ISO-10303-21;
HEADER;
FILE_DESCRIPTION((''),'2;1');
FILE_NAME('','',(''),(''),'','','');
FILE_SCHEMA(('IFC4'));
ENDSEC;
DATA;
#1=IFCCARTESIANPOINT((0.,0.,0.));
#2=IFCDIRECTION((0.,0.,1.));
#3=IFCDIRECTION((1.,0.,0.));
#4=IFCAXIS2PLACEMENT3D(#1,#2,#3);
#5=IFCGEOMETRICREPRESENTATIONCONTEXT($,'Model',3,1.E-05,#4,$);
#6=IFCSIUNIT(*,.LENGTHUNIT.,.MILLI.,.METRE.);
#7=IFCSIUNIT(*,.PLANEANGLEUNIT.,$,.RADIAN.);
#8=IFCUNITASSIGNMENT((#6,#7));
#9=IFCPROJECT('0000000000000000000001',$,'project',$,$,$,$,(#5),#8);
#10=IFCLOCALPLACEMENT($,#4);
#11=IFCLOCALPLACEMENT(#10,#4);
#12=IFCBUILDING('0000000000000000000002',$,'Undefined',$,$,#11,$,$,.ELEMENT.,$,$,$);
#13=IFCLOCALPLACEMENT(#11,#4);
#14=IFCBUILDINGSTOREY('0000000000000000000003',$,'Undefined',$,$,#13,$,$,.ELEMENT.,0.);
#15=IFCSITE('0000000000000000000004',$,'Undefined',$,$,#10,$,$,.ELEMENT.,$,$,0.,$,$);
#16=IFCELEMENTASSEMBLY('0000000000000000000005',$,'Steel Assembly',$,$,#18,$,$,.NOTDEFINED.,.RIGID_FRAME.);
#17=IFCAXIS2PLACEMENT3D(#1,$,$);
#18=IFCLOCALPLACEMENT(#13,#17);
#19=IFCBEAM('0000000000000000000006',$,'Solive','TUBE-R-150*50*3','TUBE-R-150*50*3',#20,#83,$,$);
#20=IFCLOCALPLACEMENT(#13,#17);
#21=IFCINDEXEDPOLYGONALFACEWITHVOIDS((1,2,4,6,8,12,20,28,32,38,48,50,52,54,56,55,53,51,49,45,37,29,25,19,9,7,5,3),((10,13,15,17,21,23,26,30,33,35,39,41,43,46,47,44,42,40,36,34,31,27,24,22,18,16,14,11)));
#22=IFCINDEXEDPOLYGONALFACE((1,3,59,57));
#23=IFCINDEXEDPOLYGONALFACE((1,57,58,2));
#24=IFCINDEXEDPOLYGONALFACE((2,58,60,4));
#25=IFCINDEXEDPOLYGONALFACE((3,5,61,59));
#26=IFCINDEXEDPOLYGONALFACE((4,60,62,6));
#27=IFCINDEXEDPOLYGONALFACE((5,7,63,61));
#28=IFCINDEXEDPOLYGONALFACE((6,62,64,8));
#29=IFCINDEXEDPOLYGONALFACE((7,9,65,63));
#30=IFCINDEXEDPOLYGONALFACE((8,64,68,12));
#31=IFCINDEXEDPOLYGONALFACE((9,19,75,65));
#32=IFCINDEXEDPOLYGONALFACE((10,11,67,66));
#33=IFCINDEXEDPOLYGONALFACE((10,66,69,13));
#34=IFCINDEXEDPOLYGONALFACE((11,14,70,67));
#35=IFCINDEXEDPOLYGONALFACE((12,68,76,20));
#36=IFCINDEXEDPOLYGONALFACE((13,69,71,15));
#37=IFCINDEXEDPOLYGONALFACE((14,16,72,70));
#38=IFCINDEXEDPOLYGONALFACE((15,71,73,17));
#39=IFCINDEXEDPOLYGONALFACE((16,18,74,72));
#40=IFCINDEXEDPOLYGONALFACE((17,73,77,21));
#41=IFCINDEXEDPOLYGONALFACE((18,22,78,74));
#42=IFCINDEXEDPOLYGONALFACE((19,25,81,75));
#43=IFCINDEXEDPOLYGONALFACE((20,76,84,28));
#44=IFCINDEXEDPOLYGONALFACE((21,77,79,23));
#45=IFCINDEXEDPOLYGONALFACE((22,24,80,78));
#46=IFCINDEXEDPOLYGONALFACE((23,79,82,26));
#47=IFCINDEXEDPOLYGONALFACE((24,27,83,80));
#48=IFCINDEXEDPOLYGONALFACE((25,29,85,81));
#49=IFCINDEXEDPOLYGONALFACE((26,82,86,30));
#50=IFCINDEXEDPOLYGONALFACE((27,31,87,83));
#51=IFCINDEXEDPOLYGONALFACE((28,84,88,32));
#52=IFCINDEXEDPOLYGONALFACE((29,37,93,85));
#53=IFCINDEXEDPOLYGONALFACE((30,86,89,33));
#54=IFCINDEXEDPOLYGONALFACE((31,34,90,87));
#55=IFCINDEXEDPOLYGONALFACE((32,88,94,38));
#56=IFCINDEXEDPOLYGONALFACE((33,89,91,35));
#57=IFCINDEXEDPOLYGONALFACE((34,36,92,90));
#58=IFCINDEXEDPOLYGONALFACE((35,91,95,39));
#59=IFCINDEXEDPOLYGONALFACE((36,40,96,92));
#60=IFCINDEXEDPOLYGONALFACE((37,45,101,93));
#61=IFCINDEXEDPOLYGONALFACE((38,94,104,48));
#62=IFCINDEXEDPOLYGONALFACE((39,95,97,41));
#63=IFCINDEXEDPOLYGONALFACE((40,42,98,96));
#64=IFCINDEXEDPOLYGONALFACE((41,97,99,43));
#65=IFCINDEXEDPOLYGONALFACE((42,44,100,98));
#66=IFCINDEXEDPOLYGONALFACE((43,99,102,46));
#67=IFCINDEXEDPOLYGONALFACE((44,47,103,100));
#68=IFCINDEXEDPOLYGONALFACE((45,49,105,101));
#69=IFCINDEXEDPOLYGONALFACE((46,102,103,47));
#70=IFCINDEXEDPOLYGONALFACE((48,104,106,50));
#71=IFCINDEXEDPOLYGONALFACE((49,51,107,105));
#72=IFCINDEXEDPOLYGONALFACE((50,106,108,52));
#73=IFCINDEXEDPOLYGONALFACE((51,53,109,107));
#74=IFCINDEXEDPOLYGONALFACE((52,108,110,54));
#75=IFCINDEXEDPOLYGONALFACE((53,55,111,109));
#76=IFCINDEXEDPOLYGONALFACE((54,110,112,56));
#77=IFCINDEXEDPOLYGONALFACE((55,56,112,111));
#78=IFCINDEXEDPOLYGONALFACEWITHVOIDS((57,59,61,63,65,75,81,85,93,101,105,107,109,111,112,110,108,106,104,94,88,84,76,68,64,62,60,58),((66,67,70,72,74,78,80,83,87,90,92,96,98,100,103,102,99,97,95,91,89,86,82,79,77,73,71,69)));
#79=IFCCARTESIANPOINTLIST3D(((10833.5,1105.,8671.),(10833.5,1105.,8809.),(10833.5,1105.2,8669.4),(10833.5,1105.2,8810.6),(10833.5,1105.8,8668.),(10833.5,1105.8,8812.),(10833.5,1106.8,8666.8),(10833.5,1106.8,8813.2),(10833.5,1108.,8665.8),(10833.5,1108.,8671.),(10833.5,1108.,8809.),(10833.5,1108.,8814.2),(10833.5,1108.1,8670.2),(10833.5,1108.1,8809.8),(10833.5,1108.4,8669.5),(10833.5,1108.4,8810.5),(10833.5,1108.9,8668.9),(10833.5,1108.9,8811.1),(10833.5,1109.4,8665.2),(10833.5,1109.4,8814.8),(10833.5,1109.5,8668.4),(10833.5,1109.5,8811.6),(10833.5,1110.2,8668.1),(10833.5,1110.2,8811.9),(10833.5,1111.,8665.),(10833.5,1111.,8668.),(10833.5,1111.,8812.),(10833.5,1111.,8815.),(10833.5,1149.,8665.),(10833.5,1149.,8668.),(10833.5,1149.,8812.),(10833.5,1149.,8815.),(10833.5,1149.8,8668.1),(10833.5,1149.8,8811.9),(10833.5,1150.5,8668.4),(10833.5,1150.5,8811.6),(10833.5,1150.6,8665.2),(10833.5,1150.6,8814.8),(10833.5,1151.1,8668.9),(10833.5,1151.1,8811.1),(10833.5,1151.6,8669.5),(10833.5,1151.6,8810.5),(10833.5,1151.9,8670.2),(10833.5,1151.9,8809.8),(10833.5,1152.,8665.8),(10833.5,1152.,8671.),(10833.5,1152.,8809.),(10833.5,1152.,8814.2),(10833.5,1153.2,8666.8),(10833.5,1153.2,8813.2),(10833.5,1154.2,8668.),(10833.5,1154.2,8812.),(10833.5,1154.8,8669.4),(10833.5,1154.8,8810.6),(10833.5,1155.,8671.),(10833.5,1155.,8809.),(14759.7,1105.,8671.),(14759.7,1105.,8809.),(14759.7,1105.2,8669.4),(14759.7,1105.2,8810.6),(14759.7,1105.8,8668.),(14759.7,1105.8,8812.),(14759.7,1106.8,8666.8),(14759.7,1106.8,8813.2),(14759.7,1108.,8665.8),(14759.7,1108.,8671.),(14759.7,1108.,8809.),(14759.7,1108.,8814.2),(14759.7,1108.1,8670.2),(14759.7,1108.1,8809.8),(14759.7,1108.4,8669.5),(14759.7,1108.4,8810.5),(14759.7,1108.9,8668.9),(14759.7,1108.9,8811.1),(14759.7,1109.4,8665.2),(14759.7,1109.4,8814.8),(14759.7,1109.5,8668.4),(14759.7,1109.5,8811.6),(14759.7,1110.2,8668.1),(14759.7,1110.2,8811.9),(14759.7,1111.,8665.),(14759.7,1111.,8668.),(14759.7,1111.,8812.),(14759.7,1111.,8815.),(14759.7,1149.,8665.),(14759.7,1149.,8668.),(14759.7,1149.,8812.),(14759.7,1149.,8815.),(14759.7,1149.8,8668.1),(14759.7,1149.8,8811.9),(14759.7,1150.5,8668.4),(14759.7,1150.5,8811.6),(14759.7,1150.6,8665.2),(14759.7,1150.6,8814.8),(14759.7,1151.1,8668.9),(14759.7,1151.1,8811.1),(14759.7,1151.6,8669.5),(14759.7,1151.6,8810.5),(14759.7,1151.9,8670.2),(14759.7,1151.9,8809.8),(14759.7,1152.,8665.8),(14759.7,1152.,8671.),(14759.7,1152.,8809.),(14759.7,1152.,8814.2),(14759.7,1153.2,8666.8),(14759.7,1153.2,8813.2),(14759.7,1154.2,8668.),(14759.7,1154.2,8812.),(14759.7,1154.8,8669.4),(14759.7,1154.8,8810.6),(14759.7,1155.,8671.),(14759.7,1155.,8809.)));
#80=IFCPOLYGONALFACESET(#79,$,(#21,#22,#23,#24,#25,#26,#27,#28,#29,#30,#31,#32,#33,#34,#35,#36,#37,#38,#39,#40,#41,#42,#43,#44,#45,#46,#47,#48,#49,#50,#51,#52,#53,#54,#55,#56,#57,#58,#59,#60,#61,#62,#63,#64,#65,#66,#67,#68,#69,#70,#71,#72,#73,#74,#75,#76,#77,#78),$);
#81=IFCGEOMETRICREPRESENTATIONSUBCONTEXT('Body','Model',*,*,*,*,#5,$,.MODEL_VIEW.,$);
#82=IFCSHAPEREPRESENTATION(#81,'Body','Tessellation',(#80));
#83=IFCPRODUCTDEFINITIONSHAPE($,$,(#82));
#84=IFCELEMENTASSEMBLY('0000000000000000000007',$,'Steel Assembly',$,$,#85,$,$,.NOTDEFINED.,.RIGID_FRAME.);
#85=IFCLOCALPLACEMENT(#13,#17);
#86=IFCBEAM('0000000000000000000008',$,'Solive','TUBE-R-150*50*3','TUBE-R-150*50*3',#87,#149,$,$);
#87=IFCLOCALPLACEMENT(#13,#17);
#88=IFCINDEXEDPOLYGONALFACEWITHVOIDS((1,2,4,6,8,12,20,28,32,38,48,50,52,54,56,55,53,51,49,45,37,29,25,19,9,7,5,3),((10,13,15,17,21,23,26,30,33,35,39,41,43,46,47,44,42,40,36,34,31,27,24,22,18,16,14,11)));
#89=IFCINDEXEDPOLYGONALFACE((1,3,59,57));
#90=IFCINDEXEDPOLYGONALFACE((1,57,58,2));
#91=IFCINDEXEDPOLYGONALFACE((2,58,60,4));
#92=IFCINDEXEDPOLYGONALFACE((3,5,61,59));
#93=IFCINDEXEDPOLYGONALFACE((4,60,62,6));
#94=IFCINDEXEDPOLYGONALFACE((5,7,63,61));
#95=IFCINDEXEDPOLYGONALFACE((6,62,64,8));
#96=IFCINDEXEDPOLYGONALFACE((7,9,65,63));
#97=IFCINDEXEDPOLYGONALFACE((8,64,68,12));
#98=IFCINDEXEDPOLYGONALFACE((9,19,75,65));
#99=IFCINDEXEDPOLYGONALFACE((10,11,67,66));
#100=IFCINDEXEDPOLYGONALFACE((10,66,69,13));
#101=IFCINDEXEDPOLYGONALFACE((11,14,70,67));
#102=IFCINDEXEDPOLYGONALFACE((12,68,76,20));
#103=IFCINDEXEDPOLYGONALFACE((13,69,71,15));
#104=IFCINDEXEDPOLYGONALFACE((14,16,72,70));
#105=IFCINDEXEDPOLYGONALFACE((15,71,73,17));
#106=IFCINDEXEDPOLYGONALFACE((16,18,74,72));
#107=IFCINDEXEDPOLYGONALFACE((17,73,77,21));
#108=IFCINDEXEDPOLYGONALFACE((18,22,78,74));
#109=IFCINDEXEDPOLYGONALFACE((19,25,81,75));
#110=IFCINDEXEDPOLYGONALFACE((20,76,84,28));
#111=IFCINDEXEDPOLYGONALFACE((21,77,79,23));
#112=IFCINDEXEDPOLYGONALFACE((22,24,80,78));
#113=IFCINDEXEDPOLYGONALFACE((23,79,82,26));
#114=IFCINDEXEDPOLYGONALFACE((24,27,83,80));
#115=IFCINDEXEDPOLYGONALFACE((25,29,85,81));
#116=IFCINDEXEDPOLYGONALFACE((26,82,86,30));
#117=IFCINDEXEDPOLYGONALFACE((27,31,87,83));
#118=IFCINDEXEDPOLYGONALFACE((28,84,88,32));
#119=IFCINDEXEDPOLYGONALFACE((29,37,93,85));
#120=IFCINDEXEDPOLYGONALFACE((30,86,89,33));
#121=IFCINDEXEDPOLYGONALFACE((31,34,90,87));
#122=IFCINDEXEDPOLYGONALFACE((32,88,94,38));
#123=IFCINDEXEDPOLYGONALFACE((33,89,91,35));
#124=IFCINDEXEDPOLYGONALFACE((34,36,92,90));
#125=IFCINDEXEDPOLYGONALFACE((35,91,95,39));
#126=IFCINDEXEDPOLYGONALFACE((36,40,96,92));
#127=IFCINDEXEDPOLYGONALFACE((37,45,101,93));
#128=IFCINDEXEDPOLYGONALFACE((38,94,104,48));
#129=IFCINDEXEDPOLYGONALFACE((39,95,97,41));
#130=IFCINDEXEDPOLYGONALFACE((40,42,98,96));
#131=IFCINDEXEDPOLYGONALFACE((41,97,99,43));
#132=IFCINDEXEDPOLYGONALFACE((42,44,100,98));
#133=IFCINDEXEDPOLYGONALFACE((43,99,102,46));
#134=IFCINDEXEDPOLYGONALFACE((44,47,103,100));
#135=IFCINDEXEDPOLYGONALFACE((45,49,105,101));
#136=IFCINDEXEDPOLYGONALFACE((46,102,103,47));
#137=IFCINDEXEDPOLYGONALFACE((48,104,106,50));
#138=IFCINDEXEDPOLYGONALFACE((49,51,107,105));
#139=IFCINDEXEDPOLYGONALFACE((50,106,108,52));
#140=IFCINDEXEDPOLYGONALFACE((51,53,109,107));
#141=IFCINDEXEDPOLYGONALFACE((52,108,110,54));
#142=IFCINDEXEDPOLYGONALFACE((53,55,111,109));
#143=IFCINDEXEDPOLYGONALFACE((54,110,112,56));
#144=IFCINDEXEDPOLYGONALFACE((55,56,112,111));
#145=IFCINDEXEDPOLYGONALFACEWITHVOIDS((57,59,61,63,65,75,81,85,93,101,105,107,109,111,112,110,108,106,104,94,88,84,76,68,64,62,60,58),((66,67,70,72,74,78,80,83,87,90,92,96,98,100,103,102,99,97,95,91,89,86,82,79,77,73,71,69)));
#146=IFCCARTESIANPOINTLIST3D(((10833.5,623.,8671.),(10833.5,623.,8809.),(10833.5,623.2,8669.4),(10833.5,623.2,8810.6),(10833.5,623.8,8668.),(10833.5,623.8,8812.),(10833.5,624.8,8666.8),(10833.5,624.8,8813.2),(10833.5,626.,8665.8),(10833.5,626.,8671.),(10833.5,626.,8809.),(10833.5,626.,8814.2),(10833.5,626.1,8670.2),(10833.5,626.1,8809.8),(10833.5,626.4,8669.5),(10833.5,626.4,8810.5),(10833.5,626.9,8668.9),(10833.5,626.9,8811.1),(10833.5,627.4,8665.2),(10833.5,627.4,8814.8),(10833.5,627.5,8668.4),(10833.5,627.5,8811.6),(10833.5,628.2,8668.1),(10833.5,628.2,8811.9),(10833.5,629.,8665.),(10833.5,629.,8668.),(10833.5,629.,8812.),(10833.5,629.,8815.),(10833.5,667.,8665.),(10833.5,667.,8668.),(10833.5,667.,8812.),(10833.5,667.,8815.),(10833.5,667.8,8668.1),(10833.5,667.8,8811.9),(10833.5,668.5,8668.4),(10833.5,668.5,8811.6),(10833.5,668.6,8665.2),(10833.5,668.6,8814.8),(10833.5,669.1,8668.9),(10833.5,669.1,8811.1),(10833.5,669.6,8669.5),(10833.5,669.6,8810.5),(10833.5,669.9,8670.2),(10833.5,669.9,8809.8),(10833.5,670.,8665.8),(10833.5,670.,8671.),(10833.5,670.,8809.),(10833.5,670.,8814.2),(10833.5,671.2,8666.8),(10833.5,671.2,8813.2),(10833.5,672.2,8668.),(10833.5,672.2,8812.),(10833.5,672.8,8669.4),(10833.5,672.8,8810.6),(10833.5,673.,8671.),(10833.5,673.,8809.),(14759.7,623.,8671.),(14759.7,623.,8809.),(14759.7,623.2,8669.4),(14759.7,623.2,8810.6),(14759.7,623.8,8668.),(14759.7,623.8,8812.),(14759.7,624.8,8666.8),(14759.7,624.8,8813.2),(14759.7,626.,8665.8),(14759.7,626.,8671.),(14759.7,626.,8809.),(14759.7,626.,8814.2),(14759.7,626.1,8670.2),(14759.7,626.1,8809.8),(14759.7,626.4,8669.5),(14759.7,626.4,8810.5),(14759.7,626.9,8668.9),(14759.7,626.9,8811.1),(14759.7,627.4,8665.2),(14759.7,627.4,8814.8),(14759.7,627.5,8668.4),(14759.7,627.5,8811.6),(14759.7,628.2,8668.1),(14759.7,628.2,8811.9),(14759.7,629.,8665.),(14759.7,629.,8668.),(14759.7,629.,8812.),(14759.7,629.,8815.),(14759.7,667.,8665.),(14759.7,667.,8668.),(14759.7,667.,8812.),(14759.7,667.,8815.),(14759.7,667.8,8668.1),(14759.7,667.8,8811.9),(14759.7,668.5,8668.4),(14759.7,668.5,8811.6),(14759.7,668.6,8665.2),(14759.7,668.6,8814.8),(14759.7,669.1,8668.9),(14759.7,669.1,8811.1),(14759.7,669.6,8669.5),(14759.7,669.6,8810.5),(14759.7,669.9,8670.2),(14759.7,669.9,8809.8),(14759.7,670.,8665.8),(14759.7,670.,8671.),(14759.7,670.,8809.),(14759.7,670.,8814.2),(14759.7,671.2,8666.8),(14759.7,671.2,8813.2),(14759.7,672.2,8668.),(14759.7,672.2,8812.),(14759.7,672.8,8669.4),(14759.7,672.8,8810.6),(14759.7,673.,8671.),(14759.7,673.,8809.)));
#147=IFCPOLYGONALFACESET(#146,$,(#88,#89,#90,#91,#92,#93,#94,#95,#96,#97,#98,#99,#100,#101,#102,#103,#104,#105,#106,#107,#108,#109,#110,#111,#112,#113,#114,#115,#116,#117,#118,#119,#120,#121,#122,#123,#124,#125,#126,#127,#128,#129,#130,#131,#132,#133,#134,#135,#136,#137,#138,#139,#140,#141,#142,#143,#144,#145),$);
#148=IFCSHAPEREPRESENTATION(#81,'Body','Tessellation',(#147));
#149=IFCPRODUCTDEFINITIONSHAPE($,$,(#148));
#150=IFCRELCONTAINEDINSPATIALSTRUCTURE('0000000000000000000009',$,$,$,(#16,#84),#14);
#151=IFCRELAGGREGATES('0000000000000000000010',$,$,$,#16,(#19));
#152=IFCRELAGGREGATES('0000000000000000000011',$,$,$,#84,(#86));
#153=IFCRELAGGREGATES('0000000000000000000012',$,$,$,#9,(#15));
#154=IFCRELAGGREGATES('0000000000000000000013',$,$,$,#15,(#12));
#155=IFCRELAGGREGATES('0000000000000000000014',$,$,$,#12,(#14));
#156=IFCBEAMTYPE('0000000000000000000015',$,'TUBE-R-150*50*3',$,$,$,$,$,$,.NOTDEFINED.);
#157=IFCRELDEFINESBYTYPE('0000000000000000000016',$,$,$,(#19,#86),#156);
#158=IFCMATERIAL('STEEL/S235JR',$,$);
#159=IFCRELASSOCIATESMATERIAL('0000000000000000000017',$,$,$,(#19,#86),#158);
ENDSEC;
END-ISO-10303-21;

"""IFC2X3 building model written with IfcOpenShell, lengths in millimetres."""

from ifc_helpers import new_model, si_unit, frame, origin_with_axes, origin_2d_with_axis, place, context, subcontext, project, spatial, hollow_rectangle, extrude, material, type_object, element, aggregate, save


model = new_model("IFC2X3")

# Units and contexts
model_context = context("Model", 3, precision=1e-05, world=origin_with_axes())
body_context = subcontext(model_context, "Body", "Model", "MODEL_VIEW")
ifc_project = project(units=[si_unit("LENGTHUNIT", "METRE", prefix="MILLI"), si_unit("PLANEANGLEUNIT", "RADIAN")], contexts=[model_context])

# Site, building, storey
site_placement = place(None, origin_with_axes())
site = spatial("IfcSite", under=ifc_project, at=site_placement, Name="Undefined", CompositionType="ELEMENT", RefElevation=0.0)
building_placement = place(site_placement, origin_with_axes())
building = spatial("IfcBuilding", under=site, at=building_placement, Name="Undefined", CompositionType="ELEMENT")
storey_placement = place(building_placement, origin_with_axes())
storey = spatial("IfcBuildingStorey", under=building, at=storey_placement, Name="Undefined", CompositionType="ELEMENT", Elevation=0.0)

# Element assemblies, beams
ifc_material_1 = material(Name="STEEL/S235JR")
assembly_1_placement = place(storey_placement, origin_with_axes())
assembly_1 = element("IfcElementAssembly", 1, at=assembly_1_placement, inside=storey, Name="Steel Assembly", AssemblyPlace="NOTDEFINED", PredefinedType="RIGID_FRAME")
beam_type_1 = type_object("IfcBeamType", Name="TUBE-R-150*50*3", PredefinedType="NOTDEFINED")
beam_1_placement = place(assembly_1_placement, frame((14759.7, 1130.0, 8740.0), z_axis=(0.0, 0.0, 1.0), x_axis=(-1.0, 0.0, 0.0)))
beam_1 = element("IfcBeam", 2, at=beam_1_placement, type_object=beam_type_1, material=ifc_material_1, Name="Solive", Description="TUBE-R-150*50*3", ObjectType="TUBE-R-150*50*3", context=body_context, shape_type="SweptSolid", body=[
    extrude(hollow_rectangle(XDim=50.0, YDim=150.0, WallThickness=3.0, InnerFilletRadius=3.0, OuterFilletRadius=6.0, at=origin_2d_with_axis()), frame((3926.2, 0.0, 0.0), z_axis=(-1.0, 0.0, 0.0), x_axis=(0.0, -1.0, 0.0)), (0.0, 0.0, 1.0), 3926.2),
])
aggregate(assembly_1, [beam_1])
assembly_2_placement = place(storey_placement, origin_with_axes())
assembly_2 = element("IfcElementAssembly", 3, at=assembly_2_placement, inside=storey, Name="Steel Assembly", AssemblyPlace="NOTDEFINED", PredefinedType="RIGID_FRAME")
beam_2_placement = place(assembly_2_placement, frame((14759.7, 648.0, 8740.0), z_axis=(0.0, 0.0, 1.0), x_axis=(-1.0, 0.0, 0.0)))
beam_2 = element("IfcBeam", 4, at=beam_2_placement, type_object=beam_type_1, material=ifc_material_1, Name="Solive", Description="TUBE-R-150*50*3", ObjectType="TUBE-R-150*50*3", context=body_context, shape_type="SweptSolid", body=[
    extrude(hollow_rectangle(XDim=50.0, YDim=150.0, WallThickness=3.0, InnerFilletRadius=3.0, OuterFilletRadius=6.0, at=origin_2d_with_axis()), frame((3926.2, 0.0, 0.0), z_axis=(-1.0, 0.0, 0.0), x_axis=(0.0, -1.0, 0.0)), (0.0, 0.0, 1.0), 3926.2),
])
aggregate(assembly_2, [beam_2])

save(model, "model.ifc")
